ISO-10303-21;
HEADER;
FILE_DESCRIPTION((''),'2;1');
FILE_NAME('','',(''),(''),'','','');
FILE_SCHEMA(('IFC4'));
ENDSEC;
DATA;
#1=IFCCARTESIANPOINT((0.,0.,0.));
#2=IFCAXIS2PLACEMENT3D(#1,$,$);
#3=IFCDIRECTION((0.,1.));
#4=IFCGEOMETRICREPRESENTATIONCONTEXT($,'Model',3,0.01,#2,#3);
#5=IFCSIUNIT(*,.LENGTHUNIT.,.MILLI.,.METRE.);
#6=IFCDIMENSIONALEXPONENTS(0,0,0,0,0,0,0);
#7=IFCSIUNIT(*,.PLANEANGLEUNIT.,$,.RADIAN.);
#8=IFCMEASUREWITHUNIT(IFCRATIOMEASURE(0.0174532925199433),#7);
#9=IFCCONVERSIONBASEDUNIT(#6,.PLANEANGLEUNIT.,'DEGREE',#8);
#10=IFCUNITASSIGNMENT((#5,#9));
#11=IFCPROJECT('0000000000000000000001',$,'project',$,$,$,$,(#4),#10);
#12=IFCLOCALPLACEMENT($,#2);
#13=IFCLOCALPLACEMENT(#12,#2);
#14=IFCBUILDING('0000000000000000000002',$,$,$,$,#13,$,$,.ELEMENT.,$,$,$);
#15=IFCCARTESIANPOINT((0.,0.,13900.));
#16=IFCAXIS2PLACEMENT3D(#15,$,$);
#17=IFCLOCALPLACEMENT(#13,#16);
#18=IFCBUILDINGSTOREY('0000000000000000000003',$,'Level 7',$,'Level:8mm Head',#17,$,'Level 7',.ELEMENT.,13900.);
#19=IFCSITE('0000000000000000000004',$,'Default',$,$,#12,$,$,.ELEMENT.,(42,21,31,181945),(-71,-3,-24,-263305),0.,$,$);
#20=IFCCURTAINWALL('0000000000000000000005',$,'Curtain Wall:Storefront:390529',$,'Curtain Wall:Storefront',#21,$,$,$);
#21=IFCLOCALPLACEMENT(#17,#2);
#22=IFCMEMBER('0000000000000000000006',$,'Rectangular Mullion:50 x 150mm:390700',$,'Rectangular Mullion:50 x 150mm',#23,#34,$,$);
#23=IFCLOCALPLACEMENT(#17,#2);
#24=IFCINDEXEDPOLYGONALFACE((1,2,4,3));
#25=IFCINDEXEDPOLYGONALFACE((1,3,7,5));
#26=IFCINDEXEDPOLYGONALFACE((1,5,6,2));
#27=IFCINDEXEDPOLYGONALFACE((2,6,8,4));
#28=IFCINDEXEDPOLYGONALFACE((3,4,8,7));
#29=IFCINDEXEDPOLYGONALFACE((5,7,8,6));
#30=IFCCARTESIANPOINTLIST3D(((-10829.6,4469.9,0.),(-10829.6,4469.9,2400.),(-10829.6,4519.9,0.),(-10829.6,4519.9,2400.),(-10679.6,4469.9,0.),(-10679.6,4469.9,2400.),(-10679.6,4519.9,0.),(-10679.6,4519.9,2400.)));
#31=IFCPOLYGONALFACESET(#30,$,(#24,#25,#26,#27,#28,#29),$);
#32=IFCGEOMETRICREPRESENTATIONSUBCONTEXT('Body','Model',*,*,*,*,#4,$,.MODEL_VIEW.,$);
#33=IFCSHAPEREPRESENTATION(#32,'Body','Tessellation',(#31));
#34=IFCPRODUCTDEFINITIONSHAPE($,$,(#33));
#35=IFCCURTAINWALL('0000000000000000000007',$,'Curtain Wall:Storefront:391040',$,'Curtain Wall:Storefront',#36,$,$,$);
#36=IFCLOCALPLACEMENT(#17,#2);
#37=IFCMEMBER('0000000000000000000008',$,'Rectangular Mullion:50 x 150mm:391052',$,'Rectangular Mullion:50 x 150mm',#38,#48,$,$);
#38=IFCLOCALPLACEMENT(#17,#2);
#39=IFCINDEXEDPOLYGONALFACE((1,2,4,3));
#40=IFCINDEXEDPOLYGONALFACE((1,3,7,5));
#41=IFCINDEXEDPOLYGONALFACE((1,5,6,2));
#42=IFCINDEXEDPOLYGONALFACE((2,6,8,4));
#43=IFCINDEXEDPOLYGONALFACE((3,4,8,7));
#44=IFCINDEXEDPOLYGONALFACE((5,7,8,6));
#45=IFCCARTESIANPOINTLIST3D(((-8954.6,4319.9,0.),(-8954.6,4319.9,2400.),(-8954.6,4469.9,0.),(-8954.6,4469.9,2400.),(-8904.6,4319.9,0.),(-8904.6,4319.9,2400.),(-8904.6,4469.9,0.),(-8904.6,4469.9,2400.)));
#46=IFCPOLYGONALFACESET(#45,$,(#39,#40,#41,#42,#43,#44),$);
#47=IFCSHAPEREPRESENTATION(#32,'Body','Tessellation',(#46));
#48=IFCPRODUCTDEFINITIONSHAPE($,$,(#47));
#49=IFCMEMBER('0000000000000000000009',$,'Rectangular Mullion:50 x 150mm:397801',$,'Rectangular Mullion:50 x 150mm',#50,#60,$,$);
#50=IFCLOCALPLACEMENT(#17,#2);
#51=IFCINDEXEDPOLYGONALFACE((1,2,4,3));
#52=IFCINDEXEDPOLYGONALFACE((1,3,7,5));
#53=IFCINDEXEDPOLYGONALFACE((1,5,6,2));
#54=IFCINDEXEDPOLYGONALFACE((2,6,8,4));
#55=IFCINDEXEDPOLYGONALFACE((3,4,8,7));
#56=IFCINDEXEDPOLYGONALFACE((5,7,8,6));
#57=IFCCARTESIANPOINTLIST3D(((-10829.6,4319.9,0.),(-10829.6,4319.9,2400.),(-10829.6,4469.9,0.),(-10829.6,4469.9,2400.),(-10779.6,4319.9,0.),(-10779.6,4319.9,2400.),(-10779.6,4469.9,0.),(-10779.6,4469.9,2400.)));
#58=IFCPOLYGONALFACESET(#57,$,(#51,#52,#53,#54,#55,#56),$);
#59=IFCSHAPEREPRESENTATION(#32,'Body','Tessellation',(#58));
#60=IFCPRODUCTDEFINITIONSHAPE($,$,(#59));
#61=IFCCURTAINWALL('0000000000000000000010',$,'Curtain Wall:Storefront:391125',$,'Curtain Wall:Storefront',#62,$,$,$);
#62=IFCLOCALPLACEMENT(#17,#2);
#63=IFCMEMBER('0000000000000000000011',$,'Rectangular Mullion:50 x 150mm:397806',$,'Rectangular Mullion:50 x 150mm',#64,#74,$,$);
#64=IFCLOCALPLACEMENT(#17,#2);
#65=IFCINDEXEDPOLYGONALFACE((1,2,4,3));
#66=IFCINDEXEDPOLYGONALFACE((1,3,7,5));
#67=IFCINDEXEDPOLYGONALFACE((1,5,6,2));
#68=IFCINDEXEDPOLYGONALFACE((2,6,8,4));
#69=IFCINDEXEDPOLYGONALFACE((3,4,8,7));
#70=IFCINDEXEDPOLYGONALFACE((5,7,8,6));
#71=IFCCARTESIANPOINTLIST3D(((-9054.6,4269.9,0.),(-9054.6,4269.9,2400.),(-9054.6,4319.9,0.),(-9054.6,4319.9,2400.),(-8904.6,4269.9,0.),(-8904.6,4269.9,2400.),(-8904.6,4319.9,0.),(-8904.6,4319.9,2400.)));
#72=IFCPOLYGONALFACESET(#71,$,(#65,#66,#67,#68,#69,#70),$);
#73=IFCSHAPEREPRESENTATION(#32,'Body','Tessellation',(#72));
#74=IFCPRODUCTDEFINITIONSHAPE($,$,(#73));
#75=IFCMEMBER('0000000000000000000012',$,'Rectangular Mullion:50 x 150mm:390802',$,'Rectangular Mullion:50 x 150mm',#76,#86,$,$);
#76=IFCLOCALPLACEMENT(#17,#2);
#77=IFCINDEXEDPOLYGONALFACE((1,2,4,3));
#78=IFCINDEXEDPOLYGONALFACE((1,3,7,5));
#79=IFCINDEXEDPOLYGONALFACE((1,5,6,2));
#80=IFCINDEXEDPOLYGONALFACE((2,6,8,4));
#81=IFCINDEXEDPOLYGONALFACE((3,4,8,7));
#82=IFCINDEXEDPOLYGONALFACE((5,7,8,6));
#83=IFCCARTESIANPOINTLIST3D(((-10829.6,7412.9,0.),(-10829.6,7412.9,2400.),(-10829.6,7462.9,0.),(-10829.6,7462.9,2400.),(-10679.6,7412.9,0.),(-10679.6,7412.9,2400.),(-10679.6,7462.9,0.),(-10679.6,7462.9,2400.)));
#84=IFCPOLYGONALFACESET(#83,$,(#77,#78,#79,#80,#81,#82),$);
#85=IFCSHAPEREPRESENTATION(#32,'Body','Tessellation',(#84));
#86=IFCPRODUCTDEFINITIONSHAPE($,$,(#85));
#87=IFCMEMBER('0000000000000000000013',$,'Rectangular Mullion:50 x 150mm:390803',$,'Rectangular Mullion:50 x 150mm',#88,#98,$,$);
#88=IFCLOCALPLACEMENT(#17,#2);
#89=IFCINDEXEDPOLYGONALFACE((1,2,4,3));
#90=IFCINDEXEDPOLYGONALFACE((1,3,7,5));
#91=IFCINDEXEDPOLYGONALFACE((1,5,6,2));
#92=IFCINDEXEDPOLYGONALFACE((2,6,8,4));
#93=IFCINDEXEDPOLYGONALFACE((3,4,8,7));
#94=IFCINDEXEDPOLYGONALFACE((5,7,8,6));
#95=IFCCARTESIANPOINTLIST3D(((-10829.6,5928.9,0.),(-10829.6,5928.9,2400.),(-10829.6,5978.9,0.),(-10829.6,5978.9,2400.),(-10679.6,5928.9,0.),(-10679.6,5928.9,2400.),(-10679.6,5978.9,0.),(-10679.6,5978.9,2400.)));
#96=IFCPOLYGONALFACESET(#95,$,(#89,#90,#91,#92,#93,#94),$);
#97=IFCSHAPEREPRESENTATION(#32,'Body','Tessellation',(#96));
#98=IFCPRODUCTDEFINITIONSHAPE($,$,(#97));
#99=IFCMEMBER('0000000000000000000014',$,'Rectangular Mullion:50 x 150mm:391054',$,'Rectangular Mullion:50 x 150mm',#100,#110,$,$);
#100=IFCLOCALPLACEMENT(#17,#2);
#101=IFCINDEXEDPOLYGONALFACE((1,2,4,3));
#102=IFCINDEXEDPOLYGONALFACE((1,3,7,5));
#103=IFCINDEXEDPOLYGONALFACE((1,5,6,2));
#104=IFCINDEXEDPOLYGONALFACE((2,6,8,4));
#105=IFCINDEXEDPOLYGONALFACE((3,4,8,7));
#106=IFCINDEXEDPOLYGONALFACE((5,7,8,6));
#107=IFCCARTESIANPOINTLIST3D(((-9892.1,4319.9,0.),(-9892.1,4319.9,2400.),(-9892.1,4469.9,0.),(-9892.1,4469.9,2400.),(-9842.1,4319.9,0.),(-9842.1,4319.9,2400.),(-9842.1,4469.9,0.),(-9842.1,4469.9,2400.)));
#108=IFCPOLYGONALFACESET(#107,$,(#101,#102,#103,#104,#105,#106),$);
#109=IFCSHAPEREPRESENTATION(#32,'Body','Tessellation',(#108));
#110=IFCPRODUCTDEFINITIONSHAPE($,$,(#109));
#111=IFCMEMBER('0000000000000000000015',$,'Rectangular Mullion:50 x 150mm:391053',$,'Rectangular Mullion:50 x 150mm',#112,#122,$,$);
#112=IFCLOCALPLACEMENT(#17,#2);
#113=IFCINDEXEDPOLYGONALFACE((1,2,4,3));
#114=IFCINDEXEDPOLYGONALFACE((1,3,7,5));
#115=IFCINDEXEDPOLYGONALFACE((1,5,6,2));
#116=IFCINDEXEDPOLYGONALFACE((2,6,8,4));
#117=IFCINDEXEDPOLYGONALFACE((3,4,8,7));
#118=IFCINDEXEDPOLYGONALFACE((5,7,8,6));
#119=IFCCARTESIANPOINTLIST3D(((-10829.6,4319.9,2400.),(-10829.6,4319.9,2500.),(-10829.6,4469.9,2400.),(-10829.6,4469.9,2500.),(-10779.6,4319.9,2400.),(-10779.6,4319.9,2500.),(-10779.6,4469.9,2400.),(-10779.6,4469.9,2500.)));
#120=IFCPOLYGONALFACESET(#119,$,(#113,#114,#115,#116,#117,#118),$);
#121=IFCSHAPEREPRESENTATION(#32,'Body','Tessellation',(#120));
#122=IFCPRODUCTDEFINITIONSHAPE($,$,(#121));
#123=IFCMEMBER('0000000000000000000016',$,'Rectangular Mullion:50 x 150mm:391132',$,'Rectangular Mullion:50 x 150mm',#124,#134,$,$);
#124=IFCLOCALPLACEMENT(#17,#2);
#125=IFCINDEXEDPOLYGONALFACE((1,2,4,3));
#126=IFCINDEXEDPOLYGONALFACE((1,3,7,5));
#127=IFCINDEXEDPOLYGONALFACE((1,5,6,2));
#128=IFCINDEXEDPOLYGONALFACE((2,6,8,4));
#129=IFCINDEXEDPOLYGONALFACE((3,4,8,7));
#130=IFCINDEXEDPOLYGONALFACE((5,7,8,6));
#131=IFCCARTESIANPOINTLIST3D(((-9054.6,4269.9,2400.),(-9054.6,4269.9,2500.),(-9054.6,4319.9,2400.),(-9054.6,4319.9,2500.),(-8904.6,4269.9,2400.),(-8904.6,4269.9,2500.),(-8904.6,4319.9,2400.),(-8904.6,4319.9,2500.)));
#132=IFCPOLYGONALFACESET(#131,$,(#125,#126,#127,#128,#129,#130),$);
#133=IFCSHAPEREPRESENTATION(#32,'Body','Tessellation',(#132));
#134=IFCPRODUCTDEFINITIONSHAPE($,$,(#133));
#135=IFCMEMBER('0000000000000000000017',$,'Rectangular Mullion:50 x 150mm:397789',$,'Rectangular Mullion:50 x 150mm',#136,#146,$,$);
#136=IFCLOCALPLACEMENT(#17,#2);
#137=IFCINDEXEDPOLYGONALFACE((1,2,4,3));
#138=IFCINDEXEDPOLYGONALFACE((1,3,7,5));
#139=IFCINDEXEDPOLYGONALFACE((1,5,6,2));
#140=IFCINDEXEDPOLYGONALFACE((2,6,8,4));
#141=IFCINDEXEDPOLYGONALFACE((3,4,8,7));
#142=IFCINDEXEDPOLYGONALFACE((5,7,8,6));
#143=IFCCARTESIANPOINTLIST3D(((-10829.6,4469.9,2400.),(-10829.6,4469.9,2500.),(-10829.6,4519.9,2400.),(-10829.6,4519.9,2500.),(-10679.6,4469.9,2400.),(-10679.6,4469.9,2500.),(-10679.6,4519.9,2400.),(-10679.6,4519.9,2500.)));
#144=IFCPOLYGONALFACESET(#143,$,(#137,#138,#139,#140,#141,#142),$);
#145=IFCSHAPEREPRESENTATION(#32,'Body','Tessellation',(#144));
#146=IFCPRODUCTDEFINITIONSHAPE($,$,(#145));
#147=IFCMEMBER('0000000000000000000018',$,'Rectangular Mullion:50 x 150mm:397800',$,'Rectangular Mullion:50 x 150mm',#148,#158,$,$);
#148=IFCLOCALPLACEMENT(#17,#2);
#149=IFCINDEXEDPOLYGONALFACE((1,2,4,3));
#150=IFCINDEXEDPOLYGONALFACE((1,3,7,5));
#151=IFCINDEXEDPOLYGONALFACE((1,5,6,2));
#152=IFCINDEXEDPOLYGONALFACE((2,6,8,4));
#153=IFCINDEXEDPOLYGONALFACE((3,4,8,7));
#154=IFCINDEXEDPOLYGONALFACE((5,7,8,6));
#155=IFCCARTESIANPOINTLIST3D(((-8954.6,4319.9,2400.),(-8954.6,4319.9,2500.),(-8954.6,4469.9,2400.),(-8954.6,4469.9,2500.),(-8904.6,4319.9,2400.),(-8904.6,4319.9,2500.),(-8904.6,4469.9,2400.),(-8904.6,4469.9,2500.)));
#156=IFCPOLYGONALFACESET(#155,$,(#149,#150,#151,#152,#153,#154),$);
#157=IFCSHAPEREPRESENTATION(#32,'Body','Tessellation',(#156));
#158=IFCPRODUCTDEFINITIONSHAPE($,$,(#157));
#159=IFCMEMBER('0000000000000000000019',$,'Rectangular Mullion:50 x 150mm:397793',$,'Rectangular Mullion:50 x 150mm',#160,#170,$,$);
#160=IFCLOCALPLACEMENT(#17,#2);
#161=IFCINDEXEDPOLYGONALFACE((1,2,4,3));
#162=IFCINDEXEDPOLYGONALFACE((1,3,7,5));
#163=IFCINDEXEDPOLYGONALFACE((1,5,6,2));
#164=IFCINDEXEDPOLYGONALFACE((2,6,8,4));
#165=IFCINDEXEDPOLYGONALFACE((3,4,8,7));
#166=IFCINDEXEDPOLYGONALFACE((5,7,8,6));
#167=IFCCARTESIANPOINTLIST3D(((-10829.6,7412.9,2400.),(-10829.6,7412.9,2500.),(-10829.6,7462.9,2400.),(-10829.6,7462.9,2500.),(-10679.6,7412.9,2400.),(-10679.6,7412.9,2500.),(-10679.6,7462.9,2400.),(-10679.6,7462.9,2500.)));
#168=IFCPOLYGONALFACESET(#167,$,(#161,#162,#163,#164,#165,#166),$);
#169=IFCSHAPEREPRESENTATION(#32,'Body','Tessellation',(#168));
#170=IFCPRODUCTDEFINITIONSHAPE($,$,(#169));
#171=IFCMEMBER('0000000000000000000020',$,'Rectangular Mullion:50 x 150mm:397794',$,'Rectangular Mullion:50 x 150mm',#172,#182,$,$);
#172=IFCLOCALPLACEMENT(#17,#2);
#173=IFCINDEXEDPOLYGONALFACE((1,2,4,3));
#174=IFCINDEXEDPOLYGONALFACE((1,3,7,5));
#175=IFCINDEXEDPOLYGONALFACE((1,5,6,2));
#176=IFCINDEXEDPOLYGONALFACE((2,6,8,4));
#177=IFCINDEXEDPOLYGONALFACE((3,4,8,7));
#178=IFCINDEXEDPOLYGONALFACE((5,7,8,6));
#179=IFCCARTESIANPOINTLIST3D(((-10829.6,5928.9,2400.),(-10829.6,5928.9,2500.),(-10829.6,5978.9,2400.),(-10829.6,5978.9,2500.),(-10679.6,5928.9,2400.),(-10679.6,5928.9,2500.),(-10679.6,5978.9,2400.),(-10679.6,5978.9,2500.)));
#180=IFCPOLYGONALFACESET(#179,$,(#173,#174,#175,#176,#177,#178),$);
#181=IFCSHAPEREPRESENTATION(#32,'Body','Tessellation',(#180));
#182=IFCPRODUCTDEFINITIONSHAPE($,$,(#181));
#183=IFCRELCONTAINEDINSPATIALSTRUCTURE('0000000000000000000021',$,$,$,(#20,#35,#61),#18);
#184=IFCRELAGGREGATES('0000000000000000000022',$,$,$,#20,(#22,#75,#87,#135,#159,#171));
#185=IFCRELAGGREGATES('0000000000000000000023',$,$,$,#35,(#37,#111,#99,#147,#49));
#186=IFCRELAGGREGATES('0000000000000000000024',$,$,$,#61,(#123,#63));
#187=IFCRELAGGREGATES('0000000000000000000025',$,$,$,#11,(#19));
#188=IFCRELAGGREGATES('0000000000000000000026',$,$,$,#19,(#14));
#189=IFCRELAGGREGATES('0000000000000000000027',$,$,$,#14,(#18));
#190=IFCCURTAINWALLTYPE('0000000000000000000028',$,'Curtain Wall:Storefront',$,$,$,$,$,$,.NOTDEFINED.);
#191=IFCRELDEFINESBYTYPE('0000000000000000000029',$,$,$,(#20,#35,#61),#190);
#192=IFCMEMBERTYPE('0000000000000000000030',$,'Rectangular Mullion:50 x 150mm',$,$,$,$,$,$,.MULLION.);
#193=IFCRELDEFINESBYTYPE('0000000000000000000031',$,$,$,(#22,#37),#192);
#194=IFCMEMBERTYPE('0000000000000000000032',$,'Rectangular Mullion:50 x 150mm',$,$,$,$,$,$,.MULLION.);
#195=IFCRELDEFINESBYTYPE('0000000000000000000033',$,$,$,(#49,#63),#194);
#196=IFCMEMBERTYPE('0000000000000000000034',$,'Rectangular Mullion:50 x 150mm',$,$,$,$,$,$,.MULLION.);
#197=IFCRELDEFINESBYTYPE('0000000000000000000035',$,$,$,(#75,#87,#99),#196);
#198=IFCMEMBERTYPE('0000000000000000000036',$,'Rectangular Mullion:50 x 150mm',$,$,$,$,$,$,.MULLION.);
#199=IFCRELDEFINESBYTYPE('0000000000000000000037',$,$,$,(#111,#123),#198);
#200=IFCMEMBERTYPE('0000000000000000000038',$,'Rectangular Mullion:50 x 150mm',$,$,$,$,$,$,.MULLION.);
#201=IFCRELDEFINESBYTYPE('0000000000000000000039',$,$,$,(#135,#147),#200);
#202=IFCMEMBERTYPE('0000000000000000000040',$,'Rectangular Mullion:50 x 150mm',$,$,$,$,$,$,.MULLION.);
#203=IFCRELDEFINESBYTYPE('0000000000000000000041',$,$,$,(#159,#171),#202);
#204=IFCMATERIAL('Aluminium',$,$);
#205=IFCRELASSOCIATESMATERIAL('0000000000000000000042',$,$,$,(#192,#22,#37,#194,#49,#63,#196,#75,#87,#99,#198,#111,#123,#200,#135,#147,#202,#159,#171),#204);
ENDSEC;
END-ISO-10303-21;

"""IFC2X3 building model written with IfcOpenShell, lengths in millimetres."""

from ifc_helpers import new_model, entity, si_unit, converted_unit, direction, frame, origin, origin_2d_with_axis, place, context, subcontext, project, spatial, rectangle, extrude, source, transform, mapped, material, type_object, type_shapes, element, aggregate, save


model = new_model("IFC2X3")

# Units and contexts
model_context = context("Model", 3, precision=0.01, world=origin(), true_north=direction((0.0, 1.0)))
body_context = subcontext(model_context, "Body", "Model", "MODEL_VIEW")
ifc_project = project(units=[si_unit("LENGTHUNIT", "METRE", prefix="MILLI"), converted_unit("PLANEANGLEUNIT", "DEGREE", entity("IfcRatioMeasure", 0.0174532925199433), si_unit("PLANEANGLEUNIT", "RADIAN"), dimensions=[0, 0, 0, 0, 0, 0, 0])], contexts=[model_context])

# Site, building, storey
site_placement = place(None, frame((0.0, 0.0, 0.0)))
site = spatial("IfcSite", under=ifc_project, at=site_placement, Name="Default", CompositionType="ELEMENT", RefLatitude=(42, 21, 31, 181945), RefLongitude=(-71, -3, -24, -263305), RefElevation=0.0)
building_placement = place(site_placement, origin())
building = spatial("IfcBuilding", under=site, at=building_placement, CompositionType="ELEMENT")
storey_placement = place(building_placement, frame((0.0, 0.0, 13900.0)))
storey = spatial("IfcBuildingStorey", under=building, at=storey_placement, Name="Level 7", ObjectType="Level:8mm Head", LongName="Level 7", CompositionType="ELEMENT", Elevation=13900.0)

# Curtain wall, member
curtain_wall_type = type_object("IfcCurtainWallType", Name="Curtain Wall:Storefront", PredefinedType="NOTDEFINED")
curtain_wall_1_placement = place(storey_placement, frame((0.0, 0.0, -13900.0)))
curtain_wall_1 = element("IfcCurtainWall", 1, at=curtain_wall_1_placement, inside=storey, type_object=curtain_wall_type, Name="Curtain Wall:Storefront:390529", ObjectType="Curtain Wall:Storefront")
ifc_material_1 = material(Name="Aluminium")
member_type_1 = type_object("IfcMemberType", Name="Rectangular Mullion:50 x 150mm", PredefinedType="MULLION", material=ifc_material_1)
shared_shape_1 = source(origin(), body_context, "Body", "SweptSolid", [
    extrude(rectangle(XDim=150.0, YDim=50.0, at=origin_2d_with_axis()), frame((-25.0, 0.0, -2400.0), z_axis=(0.0, 0.0, 1.0), x_axis=(0.0, -1.0, 0.0)), (0.0, 0.0, 1.0), 2400.0),
])
type_shapes(member_type_1, [shared_shape_1])
member_1_placement = place(storey_placement, frame((-10754.6, 4469.9, 0.0), z_axis=(0.0, 0.0, -1.0), x_axis=(0.0, -1.0, 0.0)))
member_1 = element("IfcMember", 2, at=member_1_placement, type_object=member_type_1, material=ifc_material_1, Name="Rectangular Mullion:50 x 150mm:390700", ObjectType="Rectangular Mullion:50 x 150mm", context=body_context, shape_type="MappedRepresentation", body=[
    mapped(shared_shape_1, transform((0.0, 0.0, 0.0), scale=1.0)),
])

# Curtain wall, members
curtain_wall_2_placement = place(storey_placement, frame((0.0, 0.0, -13900.0)))
curtain_wall_2 = element("IfcCurtainWall", 3, at=curtain_wall_2_placement, inside=storey, type_object=curtain_wall_type, Name="Curtain Wall:Storefront:391040", ObjectType="Curtain Wall:Storefront")
member_2_placement = place(building_placement, frame((-8904.6, 4394.9, 13900.0), z_axis=(0.0, 0.0, -1.0), x_axis=(1.0, 0.0, 0.0)))
member_2 = element("IfcMember", 4, at=member_2_placement, type_object=member_type_1, material=ifc_material_1, Name="Rectangular Mullion:50 x 150mm:391052", ObjectType="Rectangular Mullion:50 x 150mm", context=body_context, shape_type="MappedRepresentation", body=[
    mapped(shared_shape_1, transform((0.0, 0.0, 0.0), scale=1.0)),
])
member_type_2 = type_object("IfcMemberType", Name="Rectangular Mullion:50 x 150mm", PredefinedType="MULLION", material=ifc_material_1)
shared_shape_2 = source(origin(), body_context, "Body", "SweptSolid", [
    extrude(rectangle(XDim=150.0, YDim=50.0, at=origin_2d_with_axis()), frame((-25.0, 0.0, -2400.0), z_axis=(0.0, 0.0, 1.0), x_axis=(0.0, -1.0, 0.0)), (0.0, 0.0, 1.0), 2400.0),
])
type_shapes(member_type_2, [shared_shape_2])
member_3_placement = place(storey_placement, frame((-10829.6, 4394.9, 2400.0), z_axis=(0.0, 0.0, 1.0), x_axis=(-1.0, 0.0, 0.0)))
member_3 = element("IfcMember", 5, at=member_3_placement, type_object=member_type_2, material=ifc_material_1, Name="Rectangular Mullion:50 x 150mm:397801", ObjectType="Rectangular Mullion:50 x 150mm", context=body_context, shape_type="MappedRepresentation", body=[
    mapped(shared_shape_2, transform((0.0, 0.0, 0.0), scale=1.0)),
])

# Curtain wall, member
curtain_wall_3_placement = place(storey_placement, frame((0.0, 0.0, -13900.0)))
curtain_wall_3 = element("IfcCurtainWall", 6, at=curtain_wall_3_placement, inside=storey, type_object=curtain_wall_type, Name="Curtain Wall:Storefront:391125", ObjectType="Curtain Wall:Storefront")
member_4_placement = place(storey_placement, frame((-8979.6, 4319.9, 2400.0), z_axis=(0.0, 0.0, 1.0), x_axis=(0.0, 1.0, 0.0)))
member_4 = element("IfcMember", 7, at=member_4_placement, type_object=member_type_2, material=ifc_material_1, Name="Rectangular Mullion:50 x 150mm:397806", ObjectType="Rectangular Mullion:50 x 150mm", context=body_context, shape_type="MappedRepresentation", body=[
    mapped(shared_shape_2, transform((0.0, 0.0, 0.0), scale=1.0)),
])

# Members
member_type_3 = type_object("IfcMemberType", Name="Rectangular Mullion:50 x 150mm", PredefinedType="MULLION", material=ifc_material_1)
shared_shape_3 = source(origin(), body_context, "Body", "SweptSolid", [
    extrude(rectangle(XDim=150.0, YDim=50.0, at=origin_2d_with_axis()), frame((0.0, 0.0, -2400.0), z_axis=(0.0, 0.0, 1.0), x_axis=(0.0, -1.0, 0.0)), (0.0, 0.0, 1.0), 2400.0),
])
type_shapes(member_type_3, [shared_shape_3])
member_5_placement = place(storey_placement, frame((-10754.6, 7437.9, 0.0), z_axis=(0.0, 0.0, -1.0), x_axis=(0.0, -1.0, 0.0)))
member_5 = element("IfcMember", 8, at=member_5_placement, type_object=member_type_3, material=ifc_material_1, Name="Rectangular Mullion:50 x 150mm:390802", ObjectType="Rectangular Mullion:50 x 150mm", context=body_context, shape_type="MappedRepresentation", body=[
    mapped(shared_shape_3, transform((0.0, 0.0, 0.0), scale=1.0)),
])
member_6_placement = place(storey_placement, frame((-10754.6, 5953.9, 0.0), z_axis=(0.0, 0.0, -1.0), x_axis=(0.0, -1.0, 0.0)))
member_6 = element("IfcMember", 9, at=member_6_placement, type_object=member_type_3, material=ifc_material_1, Name="Rectangular Mullion:50 x 150mm:390803", ObjectType="Rectangular Mullion:50 x 150mm", context=body_context, shape_type="MappedRepresentation", body=[
    mapped(shared_shape_3, transform((0.0, 0.0, 0.0), scale=1.0)),
])
member_7_placement = place(building_placement, frame((-9867.1, 4394.9, 13900.0), z_axis=(0.0, 0.0, -1.0), x_axis=(1.0, 0.0, 0.0)))
member_7 = element("IfcMember", 10, at=member_7_placement, type_object=member_type_3, material=ifc_material_1, Name="Rectangular Mullion:50 x 150mm:391054", ObjectType="Rectangular Mullion:50 x 150mm", context=body_context, shape_type="MappedRepresentation", body=[
    mapped(shared_shape_3, transform((0.0, 0.0, 0.0), scale=1.0)),
])
member_type_4 = type_object("IfcMemberType", Name="Rectangular Mullion:50 x 150mm", PredefinedType="MULLION", material=ifc_material_1)
shared_shape_4 = source(origin(), body_context, "Body", "SweptSolid", [
    extrude(rectangle(XDim=150.0, YDim=50.0, at=origin_2d_with_axis()), frame((-25.0, 0.0, -100.0), z_axis=(0.0, 0.0, 1.0), x_axis=(0.0, -1.0, 0.0)), (0.0, 0.0, 1.0), 100.0),
])
type_shapes(member_type_4, [shared_shape_4])
member_8_placement = place(building_placement, frame((-10829.6, 4394.9, 16400.0), z_axis=(0.0, 0.0, 1.0), x_axis=(-1.0, 0.0, 0.0)))
member_8 = element("IfcMember", 11, at=member_8_placement, type_object=member_type_4, material=ifc_material_1, Name="Rectangular Mullion:50 x 150mm:391053", ObjectType="Rectangular Mullion:50 x 150mm", context=body_context, shape_type="MappedRepresentation", body=[
    mapped(shared_shape_4, transform((0.0, 0.0, 0.0), scale=1.0)),
])
member_9_placement = place(building_placement, frame((-8979.6, 4319.9, 16400.0), z_axis=(0.0, 0.0, 1.0), x_axis=(0.0, 1.0, 0.0)))
member_9 = element("IfcMember", 12, at=member_9_placement, type_object=member_type_4, material=ifc_material_1, Name="Rectangular Mullion:50 x 150mm:391132", ObjectType="Rectangular Mullion:50 x 150mm", context=body_context, shape_type="MappedRepresentation", body=[
    mapped(shared_shape_4, transform((0.0, 0.0, 0.0), scale=1.0)),
])
member_type_5 = type_object("IfcMemberType", Name="Rectangular Mullion:50 x 150mm", PredefinedType="MULLION", material=ifc_material_1)
shared_shape_5 = source(origin(), body_context, "Body", "SweptSolid", [
    extrude(rectangle(XDim=150.0, YDim=50.0, at=origin_2d_with_axis()), frame((-25.0, 0.0, -100.0), z_axis=(0.0, 0.0, 1.0), x_axis=(0.0, -1.0, 0.0)), (0.0, 0.0, 1.0), 100.0),
])
type_shapes(member_type_5, [shared_shape_5])
member_10_placement = place(storey_placement, frame((-10754.6, 4469.9, 2400.0), z_axis=(0.0, 0.0, -1.0), x_axis=(0.0, -1.0, 0.0)))
member_10 = element("IfcMember", 13, at=member_10_placement, type_object=member_type_5, material=ifc_material_1, Name="Rectangular Mullion:50 x 150mm:397789", ObjectType="Rectangular Mullion:50 x 150mm", context=body_context, shape_type="MappedRepresentation", body=[
    mapped(shared_shape_5, transform((0.0, 0.0, 0.0), scale=1.0)),
])
member_11_placement = place(storey_placement, frame((-8904.6, 4394.9, 2400.0), z_axis=(0.0, 0.0, -1.0), x_axis=(1.0, 0.0, 0.0)))
member_11 = element("IfcMember", 14, at=member_11_placement, type_object=member_type_5, material=ifc_material_1, Name="Rectangular Mullion:50 x 150mm:397800", ObjectType="Rectangular Mullion:50 x 150mm", context=body_context, shape_type="MappedRepresentation", body=[
    mapped(shared_shape_5, transform((0.0, 0.0, 0.0), scale=1.0)),
])
member_type_6 = type_object("IfcMemberType", Name="Rectangular Mullion:50 x 150mm", PredefinedType="MULLION", material=ifc_material_1)
shared_shape_6 = source(origin(), body_context, "Body", "SweptSolid", [
    extrude(rectangle(XDim=150.0, YDim=50.0, at=origin_2d_with_axis()), frame((0.0, 0.0, -100.0), z_axis=(0.0, 0.0, 1.0), x_axis=(0.0, -1.0, 0.0)), (0.0, 0.0, 1.0), 100.0),
])
type_shapes(member_type_6, [shared_shape_6])
member_12_placement = place(storey_placement, frame((-10754.6, 7437.9, 2400.0), z_axis=(0.0, 0.0, -1.0), x_axis=(0.0, -1.0, 0.0)))
member_12 = element("IfcMember", 15, at=member_12_placement, type_object=member_type_6, material=ifc_material_1, Name="Rectangular Mullion:50 x 150mm:397793", ObjectType="Rectangular Mullion:50 x 150mm", context=body_context, shape_type="MappedRepresentation", body=[
    mapped(shared_shape_6, transform((0.0, 0.0, 0.0), scale=1.0)),
])
member_13_placement = place(storey_placement, frame((-10754.6, 5953.9, 2400.0), z_axis=(0.0, 0.0, -1.0), x_axis=(0.0, -1.0, 0.0)))
member_13 = element("IfcMember", 16, at=member_13_placement, type_object=member_type_6, material=ifc_material_1, Name="Rectangular Mullion:50 x 150mm:397794", ObjectType="Rectangular Mullion:50 x 150mm", context=body_context, shape_type="MappedRepresentation", body=[
    mapped(shared_shape_6, transform((0.0, 0.0, 0.0), scale=1.0)),
])

aggregate(curtain_wall_1, [member_1, member_5, member_6, member_10, member_12, member_13])
aggregate(curtain_wall_2, [member_2, member_8, member_7, member_11, member_3])
aggregate(curtain_wall_3, [member_9, member_4])

save(model, "model.ifc")
